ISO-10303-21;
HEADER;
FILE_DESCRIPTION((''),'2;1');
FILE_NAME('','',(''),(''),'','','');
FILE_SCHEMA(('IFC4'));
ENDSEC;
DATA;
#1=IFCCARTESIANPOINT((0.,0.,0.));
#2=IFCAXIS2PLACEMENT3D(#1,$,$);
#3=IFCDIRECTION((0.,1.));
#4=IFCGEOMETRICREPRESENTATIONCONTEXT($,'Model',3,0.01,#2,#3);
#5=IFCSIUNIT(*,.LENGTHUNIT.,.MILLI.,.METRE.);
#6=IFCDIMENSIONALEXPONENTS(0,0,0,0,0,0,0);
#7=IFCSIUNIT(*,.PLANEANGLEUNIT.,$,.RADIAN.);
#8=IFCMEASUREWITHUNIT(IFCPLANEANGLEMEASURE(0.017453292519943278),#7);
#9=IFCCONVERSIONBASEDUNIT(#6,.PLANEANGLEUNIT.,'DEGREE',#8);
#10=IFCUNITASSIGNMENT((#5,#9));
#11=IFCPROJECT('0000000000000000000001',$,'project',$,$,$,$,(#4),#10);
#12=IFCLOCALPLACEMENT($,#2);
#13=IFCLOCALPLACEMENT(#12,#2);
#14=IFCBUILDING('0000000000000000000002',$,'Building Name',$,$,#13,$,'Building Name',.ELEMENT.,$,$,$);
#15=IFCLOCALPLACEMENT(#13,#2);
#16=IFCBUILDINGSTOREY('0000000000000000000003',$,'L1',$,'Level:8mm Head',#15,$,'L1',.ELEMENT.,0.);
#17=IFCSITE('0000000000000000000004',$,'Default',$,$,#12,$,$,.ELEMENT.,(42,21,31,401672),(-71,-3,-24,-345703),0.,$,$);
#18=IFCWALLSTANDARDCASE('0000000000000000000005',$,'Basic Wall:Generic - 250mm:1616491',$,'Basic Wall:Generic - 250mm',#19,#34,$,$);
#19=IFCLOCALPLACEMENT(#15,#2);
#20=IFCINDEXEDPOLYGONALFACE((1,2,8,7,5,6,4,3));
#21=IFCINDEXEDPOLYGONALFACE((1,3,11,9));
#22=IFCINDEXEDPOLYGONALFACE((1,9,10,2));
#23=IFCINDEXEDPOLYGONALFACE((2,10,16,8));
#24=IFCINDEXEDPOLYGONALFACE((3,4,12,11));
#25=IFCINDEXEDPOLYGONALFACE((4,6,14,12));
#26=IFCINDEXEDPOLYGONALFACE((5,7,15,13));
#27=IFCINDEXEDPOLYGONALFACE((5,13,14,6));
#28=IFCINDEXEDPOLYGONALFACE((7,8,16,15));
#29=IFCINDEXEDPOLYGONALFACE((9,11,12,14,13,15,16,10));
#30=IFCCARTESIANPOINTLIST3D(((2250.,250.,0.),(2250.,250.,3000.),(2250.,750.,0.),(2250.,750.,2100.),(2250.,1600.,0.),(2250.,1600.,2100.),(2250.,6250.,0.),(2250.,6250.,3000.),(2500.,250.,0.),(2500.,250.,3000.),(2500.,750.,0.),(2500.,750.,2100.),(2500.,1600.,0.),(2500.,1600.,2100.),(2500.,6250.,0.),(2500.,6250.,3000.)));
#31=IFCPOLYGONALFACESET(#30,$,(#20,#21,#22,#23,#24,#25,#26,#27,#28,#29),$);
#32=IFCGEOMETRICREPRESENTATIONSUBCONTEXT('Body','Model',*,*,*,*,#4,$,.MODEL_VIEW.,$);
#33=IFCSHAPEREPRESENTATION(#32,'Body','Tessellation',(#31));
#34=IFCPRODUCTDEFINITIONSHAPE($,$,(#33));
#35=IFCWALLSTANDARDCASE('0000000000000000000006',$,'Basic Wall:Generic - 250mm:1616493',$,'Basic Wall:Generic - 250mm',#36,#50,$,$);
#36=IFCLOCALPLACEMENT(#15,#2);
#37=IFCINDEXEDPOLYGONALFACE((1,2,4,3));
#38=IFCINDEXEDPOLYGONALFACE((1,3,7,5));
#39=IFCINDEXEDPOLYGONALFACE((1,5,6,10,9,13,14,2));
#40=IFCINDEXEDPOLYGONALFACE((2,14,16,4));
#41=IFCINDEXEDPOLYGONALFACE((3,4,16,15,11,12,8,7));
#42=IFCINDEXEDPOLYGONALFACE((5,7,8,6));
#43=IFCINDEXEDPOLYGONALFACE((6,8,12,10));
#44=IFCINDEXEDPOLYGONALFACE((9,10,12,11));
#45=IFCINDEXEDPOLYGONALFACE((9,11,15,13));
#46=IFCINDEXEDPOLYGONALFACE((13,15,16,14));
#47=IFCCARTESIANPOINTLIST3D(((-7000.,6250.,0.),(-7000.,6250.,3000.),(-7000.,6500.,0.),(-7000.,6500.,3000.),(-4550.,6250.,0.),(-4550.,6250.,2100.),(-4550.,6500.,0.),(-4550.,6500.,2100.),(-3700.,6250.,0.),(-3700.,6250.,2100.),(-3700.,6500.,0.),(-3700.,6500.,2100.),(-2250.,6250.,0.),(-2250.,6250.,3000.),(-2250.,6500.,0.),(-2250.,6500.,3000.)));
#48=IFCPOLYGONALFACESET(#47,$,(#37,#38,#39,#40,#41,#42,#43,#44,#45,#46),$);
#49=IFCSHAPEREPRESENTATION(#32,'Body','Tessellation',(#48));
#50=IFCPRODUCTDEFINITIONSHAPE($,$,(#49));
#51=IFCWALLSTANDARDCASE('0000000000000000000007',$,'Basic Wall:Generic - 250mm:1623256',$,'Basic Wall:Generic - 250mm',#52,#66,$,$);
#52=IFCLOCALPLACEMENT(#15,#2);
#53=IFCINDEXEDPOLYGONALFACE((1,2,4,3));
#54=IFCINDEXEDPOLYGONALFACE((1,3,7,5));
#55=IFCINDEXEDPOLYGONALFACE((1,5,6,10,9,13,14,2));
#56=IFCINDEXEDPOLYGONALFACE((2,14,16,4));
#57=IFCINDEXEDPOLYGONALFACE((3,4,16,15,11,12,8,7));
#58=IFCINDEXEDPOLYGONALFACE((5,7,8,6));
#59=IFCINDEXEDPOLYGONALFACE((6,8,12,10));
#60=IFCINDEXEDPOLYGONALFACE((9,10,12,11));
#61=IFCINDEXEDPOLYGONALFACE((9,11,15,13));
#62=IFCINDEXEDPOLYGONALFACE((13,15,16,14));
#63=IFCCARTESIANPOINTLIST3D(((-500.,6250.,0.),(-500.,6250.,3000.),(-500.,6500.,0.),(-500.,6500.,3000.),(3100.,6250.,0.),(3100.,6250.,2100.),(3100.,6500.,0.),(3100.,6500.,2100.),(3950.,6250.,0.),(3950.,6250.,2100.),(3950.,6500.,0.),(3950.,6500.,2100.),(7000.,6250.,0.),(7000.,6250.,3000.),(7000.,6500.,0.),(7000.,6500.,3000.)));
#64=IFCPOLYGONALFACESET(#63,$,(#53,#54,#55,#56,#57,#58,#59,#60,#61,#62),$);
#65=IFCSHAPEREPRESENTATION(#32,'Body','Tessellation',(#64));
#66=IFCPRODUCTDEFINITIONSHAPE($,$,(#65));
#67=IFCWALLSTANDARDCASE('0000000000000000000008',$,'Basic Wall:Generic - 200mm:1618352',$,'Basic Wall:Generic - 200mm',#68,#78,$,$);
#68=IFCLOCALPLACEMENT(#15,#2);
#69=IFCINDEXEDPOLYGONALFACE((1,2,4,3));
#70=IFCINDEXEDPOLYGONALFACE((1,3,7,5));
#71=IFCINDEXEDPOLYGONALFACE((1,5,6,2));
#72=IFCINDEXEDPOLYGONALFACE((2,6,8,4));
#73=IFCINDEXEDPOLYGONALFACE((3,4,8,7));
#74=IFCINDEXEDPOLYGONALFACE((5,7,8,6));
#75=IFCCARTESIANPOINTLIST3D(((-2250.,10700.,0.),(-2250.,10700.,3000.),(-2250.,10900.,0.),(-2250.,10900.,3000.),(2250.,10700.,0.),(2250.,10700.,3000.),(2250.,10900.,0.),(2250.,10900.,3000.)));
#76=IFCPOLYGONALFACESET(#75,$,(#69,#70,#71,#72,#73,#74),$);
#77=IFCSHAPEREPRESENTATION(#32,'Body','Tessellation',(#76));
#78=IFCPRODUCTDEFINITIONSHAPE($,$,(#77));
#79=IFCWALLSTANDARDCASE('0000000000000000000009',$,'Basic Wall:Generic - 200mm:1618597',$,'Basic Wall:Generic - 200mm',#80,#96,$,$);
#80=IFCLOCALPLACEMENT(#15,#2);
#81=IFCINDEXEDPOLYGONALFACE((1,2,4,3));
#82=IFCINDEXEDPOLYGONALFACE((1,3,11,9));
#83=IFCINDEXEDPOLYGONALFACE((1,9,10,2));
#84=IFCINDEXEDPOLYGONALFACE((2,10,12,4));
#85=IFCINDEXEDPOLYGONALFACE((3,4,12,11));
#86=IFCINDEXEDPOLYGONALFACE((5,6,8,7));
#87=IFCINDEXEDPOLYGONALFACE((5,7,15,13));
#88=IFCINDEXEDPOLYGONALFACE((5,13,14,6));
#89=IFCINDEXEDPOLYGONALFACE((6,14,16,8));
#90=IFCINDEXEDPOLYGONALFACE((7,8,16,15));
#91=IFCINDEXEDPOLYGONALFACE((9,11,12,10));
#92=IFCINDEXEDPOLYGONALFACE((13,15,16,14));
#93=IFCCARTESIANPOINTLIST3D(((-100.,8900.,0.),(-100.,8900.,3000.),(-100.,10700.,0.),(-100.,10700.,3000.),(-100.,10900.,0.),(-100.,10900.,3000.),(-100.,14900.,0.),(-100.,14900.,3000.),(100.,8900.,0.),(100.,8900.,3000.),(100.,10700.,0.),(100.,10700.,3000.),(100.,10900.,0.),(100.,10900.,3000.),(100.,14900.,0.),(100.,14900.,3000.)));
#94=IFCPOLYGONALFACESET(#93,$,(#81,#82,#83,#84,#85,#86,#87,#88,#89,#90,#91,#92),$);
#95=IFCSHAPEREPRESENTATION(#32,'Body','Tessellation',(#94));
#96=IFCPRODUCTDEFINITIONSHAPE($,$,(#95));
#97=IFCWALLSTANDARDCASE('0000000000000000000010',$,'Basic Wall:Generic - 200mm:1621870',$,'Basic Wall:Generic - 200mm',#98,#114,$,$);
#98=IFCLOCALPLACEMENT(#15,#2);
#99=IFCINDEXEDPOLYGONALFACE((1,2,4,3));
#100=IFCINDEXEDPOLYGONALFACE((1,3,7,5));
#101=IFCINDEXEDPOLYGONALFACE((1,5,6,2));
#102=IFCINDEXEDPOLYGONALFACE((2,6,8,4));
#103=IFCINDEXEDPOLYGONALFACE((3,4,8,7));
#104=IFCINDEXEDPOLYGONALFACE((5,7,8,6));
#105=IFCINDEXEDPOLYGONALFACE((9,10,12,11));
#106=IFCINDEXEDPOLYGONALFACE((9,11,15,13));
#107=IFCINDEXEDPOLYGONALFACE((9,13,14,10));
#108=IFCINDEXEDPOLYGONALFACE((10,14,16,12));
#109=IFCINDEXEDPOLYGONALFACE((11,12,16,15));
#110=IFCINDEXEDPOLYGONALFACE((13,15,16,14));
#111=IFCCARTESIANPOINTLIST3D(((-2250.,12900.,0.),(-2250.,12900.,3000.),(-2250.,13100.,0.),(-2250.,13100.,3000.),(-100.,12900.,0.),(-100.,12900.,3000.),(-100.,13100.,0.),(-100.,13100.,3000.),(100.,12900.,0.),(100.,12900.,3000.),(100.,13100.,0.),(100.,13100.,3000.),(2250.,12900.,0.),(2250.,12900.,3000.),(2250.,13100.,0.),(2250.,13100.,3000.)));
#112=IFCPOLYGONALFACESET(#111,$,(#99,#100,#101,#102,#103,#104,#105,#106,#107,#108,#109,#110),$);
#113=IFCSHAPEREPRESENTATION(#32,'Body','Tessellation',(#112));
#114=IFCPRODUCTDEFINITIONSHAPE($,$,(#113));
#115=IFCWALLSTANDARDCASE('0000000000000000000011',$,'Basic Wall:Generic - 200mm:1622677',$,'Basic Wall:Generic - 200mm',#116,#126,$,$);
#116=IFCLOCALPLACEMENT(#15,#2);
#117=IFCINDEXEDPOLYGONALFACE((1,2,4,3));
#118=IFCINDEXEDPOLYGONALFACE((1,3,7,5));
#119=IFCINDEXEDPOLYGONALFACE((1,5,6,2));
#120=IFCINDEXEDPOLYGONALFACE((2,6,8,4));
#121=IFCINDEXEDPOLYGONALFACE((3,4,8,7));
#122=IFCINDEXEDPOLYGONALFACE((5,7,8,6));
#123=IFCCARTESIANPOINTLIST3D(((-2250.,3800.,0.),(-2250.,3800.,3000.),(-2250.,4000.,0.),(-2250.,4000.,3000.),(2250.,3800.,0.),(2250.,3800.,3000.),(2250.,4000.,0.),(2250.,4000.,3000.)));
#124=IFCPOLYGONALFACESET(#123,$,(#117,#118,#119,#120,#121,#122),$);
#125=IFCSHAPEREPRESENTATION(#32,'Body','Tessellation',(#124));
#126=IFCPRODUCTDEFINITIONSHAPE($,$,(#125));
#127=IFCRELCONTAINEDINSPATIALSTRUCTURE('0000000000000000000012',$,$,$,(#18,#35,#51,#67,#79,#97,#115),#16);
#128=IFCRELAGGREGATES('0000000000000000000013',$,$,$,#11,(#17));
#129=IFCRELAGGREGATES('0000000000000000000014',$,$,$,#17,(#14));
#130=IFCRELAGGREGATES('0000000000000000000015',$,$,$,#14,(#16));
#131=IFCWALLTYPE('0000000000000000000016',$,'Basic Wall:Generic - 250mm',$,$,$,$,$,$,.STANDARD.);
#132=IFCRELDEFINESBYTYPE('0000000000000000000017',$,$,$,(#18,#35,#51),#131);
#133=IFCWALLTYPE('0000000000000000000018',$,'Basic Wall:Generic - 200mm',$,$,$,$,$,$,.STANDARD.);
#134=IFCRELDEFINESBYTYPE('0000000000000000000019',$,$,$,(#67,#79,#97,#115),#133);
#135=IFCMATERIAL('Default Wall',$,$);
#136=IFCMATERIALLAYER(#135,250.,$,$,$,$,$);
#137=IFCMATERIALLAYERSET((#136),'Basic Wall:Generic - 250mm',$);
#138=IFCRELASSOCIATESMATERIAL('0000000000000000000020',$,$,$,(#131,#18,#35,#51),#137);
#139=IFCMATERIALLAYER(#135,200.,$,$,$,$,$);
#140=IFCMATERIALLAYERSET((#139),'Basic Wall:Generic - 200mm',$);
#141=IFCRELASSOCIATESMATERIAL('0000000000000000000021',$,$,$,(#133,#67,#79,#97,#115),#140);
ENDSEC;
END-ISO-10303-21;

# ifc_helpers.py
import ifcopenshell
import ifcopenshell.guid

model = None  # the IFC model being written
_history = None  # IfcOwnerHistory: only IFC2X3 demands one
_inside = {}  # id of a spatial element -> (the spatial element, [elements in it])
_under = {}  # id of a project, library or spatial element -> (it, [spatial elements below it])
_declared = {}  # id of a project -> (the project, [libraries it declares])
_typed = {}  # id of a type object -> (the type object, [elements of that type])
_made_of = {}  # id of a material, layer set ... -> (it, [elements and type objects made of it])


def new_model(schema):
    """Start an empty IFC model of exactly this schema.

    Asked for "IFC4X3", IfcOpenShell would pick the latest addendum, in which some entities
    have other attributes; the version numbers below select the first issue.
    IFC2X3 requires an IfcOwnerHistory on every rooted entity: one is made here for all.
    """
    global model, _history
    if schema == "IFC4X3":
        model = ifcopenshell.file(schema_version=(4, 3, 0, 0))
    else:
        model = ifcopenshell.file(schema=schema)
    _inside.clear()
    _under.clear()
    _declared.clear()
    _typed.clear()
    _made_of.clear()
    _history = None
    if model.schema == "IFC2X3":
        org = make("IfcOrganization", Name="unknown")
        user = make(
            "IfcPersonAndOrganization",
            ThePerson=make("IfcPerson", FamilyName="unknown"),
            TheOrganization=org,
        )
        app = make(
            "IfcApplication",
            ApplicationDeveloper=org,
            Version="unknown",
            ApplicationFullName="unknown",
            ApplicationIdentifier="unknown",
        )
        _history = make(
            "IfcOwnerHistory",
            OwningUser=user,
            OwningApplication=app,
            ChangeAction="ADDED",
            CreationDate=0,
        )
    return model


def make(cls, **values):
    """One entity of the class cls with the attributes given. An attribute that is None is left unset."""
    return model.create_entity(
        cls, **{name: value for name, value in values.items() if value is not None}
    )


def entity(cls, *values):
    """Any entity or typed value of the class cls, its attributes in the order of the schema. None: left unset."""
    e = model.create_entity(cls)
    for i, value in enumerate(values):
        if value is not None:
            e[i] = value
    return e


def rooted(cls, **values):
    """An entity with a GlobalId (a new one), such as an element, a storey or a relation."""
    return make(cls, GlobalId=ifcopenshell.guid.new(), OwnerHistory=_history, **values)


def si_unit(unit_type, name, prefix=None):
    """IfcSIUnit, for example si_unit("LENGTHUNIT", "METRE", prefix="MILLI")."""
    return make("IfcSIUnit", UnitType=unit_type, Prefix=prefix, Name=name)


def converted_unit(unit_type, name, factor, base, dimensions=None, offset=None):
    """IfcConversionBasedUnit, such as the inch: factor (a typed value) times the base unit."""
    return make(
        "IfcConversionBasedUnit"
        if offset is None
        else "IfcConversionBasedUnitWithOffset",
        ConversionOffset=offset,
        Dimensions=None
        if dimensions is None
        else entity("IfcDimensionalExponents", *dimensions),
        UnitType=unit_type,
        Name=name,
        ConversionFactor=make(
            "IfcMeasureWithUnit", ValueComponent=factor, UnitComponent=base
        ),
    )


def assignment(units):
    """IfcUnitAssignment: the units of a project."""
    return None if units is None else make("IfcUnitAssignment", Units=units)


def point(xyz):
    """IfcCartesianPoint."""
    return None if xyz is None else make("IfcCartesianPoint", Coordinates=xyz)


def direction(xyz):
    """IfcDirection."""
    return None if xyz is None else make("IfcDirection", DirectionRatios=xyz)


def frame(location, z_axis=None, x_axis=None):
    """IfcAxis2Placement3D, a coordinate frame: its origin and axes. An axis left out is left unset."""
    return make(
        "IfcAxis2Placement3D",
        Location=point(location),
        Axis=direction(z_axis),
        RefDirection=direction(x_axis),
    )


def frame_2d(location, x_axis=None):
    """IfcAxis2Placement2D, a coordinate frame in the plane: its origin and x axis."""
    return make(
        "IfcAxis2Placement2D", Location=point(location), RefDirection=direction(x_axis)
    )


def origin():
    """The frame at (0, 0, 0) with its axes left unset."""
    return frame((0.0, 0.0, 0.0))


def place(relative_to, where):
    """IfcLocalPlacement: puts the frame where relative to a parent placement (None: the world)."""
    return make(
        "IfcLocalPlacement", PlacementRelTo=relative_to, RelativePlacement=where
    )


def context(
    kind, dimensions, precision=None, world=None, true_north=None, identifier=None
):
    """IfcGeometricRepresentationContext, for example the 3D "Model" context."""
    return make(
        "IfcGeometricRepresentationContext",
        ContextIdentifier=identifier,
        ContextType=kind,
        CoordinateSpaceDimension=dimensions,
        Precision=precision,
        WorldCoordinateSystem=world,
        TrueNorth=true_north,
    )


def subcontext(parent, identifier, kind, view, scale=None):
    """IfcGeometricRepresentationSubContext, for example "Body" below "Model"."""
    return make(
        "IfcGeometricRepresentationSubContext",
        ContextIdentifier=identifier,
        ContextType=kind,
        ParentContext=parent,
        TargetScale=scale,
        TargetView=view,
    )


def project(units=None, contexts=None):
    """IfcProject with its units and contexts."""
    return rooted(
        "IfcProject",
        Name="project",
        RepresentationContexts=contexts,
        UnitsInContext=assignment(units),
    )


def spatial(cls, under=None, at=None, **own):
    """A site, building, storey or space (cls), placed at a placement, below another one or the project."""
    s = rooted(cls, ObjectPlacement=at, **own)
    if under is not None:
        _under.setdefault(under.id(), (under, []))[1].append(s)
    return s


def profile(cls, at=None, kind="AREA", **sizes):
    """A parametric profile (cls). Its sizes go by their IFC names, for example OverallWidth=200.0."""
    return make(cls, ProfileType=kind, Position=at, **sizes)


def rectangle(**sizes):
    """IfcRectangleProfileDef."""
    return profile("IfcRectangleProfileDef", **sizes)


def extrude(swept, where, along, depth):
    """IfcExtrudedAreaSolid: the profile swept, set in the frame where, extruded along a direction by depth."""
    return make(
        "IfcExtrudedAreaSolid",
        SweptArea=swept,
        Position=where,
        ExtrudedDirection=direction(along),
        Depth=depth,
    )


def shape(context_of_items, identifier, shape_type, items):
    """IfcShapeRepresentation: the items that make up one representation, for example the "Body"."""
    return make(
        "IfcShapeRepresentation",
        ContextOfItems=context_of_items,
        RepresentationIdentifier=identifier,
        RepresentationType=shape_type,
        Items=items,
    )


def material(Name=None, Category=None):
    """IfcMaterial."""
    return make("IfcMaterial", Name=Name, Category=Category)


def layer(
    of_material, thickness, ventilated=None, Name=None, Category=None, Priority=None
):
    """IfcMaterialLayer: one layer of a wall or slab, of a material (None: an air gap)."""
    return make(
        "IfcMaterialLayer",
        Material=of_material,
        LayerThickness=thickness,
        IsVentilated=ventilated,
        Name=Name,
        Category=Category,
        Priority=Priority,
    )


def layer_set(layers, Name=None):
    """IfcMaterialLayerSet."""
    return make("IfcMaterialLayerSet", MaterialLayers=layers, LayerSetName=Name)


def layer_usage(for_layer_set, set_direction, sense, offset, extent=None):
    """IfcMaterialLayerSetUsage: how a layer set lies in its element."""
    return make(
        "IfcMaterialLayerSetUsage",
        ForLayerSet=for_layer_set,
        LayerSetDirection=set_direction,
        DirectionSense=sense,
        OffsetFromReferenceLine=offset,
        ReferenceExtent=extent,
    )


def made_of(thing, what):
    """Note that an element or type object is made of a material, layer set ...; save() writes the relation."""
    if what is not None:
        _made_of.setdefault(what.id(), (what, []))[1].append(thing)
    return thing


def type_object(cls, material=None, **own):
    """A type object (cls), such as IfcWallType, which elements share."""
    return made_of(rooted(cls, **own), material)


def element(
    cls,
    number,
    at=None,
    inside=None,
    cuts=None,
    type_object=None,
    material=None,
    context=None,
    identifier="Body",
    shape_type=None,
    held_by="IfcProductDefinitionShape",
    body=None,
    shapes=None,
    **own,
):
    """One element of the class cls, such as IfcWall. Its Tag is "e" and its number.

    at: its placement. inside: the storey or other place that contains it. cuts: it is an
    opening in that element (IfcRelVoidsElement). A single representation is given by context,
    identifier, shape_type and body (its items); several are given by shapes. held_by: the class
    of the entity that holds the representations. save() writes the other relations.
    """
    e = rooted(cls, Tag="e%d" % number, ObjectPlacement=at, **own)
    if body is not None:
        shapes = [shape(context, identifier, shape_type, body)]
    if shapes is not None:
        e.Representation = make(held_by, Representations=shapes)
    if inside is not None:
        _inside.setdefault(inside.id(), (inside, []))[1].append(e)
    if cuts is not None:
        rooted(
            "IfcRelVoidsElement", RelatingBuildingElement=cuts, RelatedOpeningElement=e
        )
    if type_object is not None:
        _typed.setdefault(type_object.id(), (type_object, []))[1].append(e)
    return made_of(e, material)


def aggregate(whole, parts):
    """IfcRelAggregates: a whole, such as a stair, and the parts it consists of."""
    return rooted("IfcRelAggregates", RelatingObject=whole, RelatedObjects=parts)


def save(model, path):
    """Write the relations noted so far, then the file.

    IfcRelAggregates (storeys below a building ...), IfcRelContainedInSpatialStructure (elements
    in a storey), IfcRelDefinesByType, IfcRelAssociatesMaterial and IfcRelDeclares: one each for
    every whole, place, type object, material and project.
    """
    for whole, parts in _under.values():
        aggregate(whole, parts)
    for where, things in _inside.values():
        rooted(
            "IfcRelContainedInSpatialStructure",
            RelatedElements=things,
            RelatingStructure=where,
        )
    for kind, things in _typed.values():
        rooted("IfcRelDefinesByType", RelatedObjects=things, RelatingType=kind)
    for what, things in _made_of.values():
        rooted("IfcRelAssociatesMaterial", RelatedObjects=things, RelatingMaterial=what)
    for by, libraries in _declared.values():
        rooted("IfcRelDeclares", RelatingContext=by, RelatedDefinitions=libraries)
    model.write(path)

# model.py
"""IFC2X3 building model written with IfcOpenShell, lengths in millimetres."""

from ifc_helpers import new_model, entity, si_unit, converted_unit, direction, frame, frame_2d, origin, place, context, subcontext, project, spatial, rectangle, extrude, material, layer, layer_set, layer_usage, type_object, element, save


model = new_model("IFC2X3")

# Units and contexts
model_context = context("Model", 3, precision=0.01, world=origin(), true_north=direction((0.0, 1.0)))
body_context = subcontext(model_context, "Body", "Model", "MODEL_VIEW")
ifc_project = project(units=[si_unit("LENGTHUNIT", "METRE", prefix="MILLI"), converted_unit("PLANEANGLEUNIT", "DEGREE", entity("IfcPlaneAngleMeasure", 0.017453292519943278), si_unit("PLANEANGLEUNIT", "RADIAN"), dimensions=[0, 0, 0, 0, 0, 0, 0])], contexts=[model_context])

# Site, building, storey
site_placement = place(None, origin())
site = spatial("IfcSite", under=ifc_project, at=site_placement, Name="Default", CompositionType="ELEMENT", RefLatitude=(42, 21, 31, 401672), RefLongitude=(-71, -3, -24, -345703), RefElevation=0.0)
building_placement = place(site_placement, origin())
building = spatial("IfcBuilding", under=site, at=building_placement, Name="Building Name", LongName="Building Name", CompositionType="ELEMENT")
storey_placement = place(building_placement, origin())
storey = spatial("IfcBuildingStorey", under=building, at=storey_placement, Name="L1", ObjectType="Level:8mm Head", LongName="L1", CompositionType="ELEMENT", Elevation=0.0)

# Shared definitions
ifc_material = material(Name="Default Wall")
ifc_layer_1 = layer(ifc_material, 250.0)
ifc_layer_set_1 = layer_set([ifc_layer_1], Name="Basic Wall:Generic - 250mm")
wall_type_1 = type_object("IfcWallType", Name="Basic Wall:Generic - 250mm", PredefinedType="STANDARD", material=ifc_layer_set_1)

# Walls, openings
ifc_layer_usage_1 = layer_usage(ifc_layer_set_1, "AXIS2", "NEGATIVE", 125.0)
wall_1_placement = place(storey_placement, frame((2375.0, 250.0, 0.0), z_axis=(0.0, 0.0, 1.0), x_axis=(0.0, 1.0, 0.0)))
wall_1 = element("IfcWallStandardCase", 1, at=wall_1_placement, inside=storey, type_object=wall_type_1, material=ifc_layer_usage_1, Name="Basic Wall:Generic - 250mm:1616491", ObjectType="Basic Wall:Generic - 250mm", context=body_context, shape_type="SweptSolid", body=[
    extrude(rectangle(XDim=6000.0, YDim=250.0, at=frame_2d((3000.0, 0.0), x_axis=(1.0, 0.0))), origin(), (0.0, 0.0, 1.0), 3000.0),
])
opening_1_placement = place(wall_1_placement, frame((500.0, -125.0, 0.0)))
element("IfcOpeningElement", 2, at=opening_1_placement, cuts=wall_1, ObjectType="Opening", context=body_context, shape_type="SweptSolid", body=[
    extrude(rectangle(XDim=2100.0, YDim=850.0, at=frame_2d((1050.0, 425.0), x_axis=(1.0, 0.0))), frame((0.0, 0.0, 0.0), z_axis=(0.0, 1.0, 0.0), x_axis=(0.0, 0.0, 1.0)), (0.0, 0.0, 1.0), 250.0),
])
ifc_layer_usage_2 = layer_usage(ifc_layer_set_1, "AXIS2", "NEGATIVE", 125.0)
wall_2_placement = place(storey_placement, frame((-7000.0, 6375.0, 0.0)))
wall_2 = element("IfcWallStandardCase", 3, at=wall_2_placement, inside=storey, type_object=wall_type_1, material=ifc_layer_usage_2, Name="Basic Wall:Generic - 250mm:1616493", ObjectType="Basic Wall:Generic - 250mm", context=body_context, shape_type="SweptSolid", body=[
    extrude(rectangle(XDim=4750.0, YDim=250.0, at=frame_2d((2375.0, 0.0), x_axis=(1.0, 0.0))), origin(), (0.0, 0.0, 1.0), 3000.0),
])
opening_2_placement = place(wall_2_placement, frame((3300.0, 125.0, 0.0)))
element("IfcOpeningElement", 4, at=opening_2_placement, cuts=wall_2, ObjectType="Opening", context=body_context, shape_type="SweptSolid", body=[
    extrude(rectangle(XDim=2100.0, YDim=850.0, at=frame_2d((1050.0, 425.0), x_axis=(1.0, 0.0))), frame((0.0, 0.0, 0.0), z_axis=(0.0, -1.0, 0.0), x_axis=(0.0, 0.0, 1.0)), (0.0, 0.0, 1.0), 250.0),
])

# Wall, openings
ifc_layer_usage_3 = layer_usage(ifc_layer_set_1, "AXIS2", "NEGATIVE", 125.0)
wall_3_placement = place(storey_placement, frame((-500.0, 6375.0, 0.0)))
wall_3 = element("IfcWallStandardCase", 5, at=wall_3_placement, inside=storey, type_object=wall_type_1, material=ifc_layer_usage_3, Name="Basic Wall:Generic - 250mm:1623256", ObjectType="Basic Wall:Generic - 250mm", context=body_context, shape_type="SweptSolid", body=[
    extrude(rectangle(XDim=7500.0, YDim=250.0, at=frame_2d((3750.0, 0.0), x_axis=(1.0, 0.0))), origin(), (0.0, 0.0, 1.0), 3000.0),
])
opening_3_placement = place(wall_3_placement, frame((4450.0, 125.0, 0.0)))
element("IfcOpeningElement", 6, at=opening_3_placement, cuts=wall_3, ObjectType="Opening", context=body_context, shape_type="SweptSolid", body=[
    extrude(rectangle(XDim=2100.0, YDim=850.0, at=frame_2d((1050.0, 425.0), x_axis=(1.0, 0.0))), frame((0.0, 0.0, 0.0), z_axis=(0.0, -1.0, 0.0), x_axis=(0.0, 0.0, 1.0)), (0.0, 0.0, 1.0), 250.0),
])
opening_4_placement = place(wall_3_placement, frame((500.0, -6375.0, 0.0)))
element("IfcOpeningElement", 7, at=opening_4_placement, cuts=wall_3, ObjectType="Opening", context=body_context, shape_type="SweptSolid", body=[
    extrude(rectangle(XDim=2100.0, YDim=850.0, at=frame_2d((0.0, 0.0), x_axis=(1.0, 0.0))), frame((3525.0, 4976.0, 1050.0), z_axis=(0.0, 1.0, 0.0), x_axis=(0.0, 0.0, 1.0)), (0.0, 0.0, 1.0), 3048.0),
])

# Wall
ifc_layer_2 = layer(ifc_material, 200.0)
ifc_layer_set_2 = layer_set([ifc_layer_2], Name="Basic Wall:Generic - 200mm")
ifc_layer_usage_4 = layer_usage(ifc_layer_set_2, "AXIS2", "NEGATIVE", 100.0)
wall_type_2 = type_object("IfcWallType", Name="Basic Wall:Generic - 200mm", PredefinedType="STANDARD", material=ifc_layer_set_2)
wall_4_placement = place(storey_placement, frame((-2250.0, 10800.0, 0.0)))
element("IfcWallStandardCase", 8, at=wall_4_placement, inside=storey, type_object=wall_type_2, material=ifc_layer_usage_4, Name="Basic Wall:Generic - 200mm:1618352", ObjectType="Basic Wall:Generic - 200mm", context=body_context, shape_type="SweptSolid", body=[
    extrude(rectangle(XDim=4500.0, YDim=200.0, at=frame_2d((2250.0, 0.0), x_axis=(-1.0, 0.0))), origin(), (0.0, 0.0, 1.0), 3000.0),
])

# Walls, openings
ifc_layer_usage_5 = layer_usage(ifc_layer_set_2, "AXIS2", "NEGATIVE", 100.0)
wall_5_placement = place(storey_placement, frame((0.0, 8900.0, 0.0), z_axis=(0.0, 0.0, 1.0), x_axis=(0.0, 1.0, 0.0)))
wall_5 = element("IfcWallStandardCase", 9, at=wall_5_placement, inside=storey, type_object=wall_type_2, material=ifc_layer_usage_5, Name="Basic Wall:Generic - 200mm:1618597", ObjectType="Basic Wall:Generic - 200mm", context=body_context, shape_type="SweptSolid", body=[
    extrude(rectangle(XDim=6000.0, YDim=200.0, at=frame_2d((3000.0, 0.0), x_axis=(-1.0, 0.0))), origin(), (0.0, 0.0, 1.0), 3000.0),
])
opening_5_placement = place(storey_placement, frame((0.0, 8900.0, 0.0), z_axis=(0.0, 0.0, 1.0), x_axis=(0.0, 1.0, 0.0)))
element("IfcOpeningElement", 10, at=opening_5_placement, cuts=wall_5, ObjectType="Opening", context=body_context, shape_type="SweptSolid", body=[
    extrude(rectangle(XDim=3000.0, YDim=200.0, at=frame_2d((0.0, 0.0), x_axis=(1.0, 0.0))), frame((1800.0, 0.0, 1500.0), z_axis=(1.0, 0.0, 0.0), x_axis=(0.0, 0.0, -1.0)), (0.0, 0.0, 1.0), 200.0),
])
ifc_layer_usage_6 = layer_usage(ifc_layer_set_2, "AXIS2", "NEGATIVE", 100.0)
wall_6_placement = place(storey_placement, frame((-2250.0, 13000.0, 0.0)))
wall_6 = element("IfcWallStandardCase", 11, at=wall_6_placement, inside=storey, type_object=wall_type_2, material=ifc_layer_usage_6, Name="Basic Wall:Generic - 200mm:1621870", ObjectType="Basic Wall:Generic - 200mm", context=body_context, shape_type="SweptSolid", body=[
    extrude(rectangle(XDim=4500.0, YDim=200.0, at=frame_2d((2250.0, 0.0), x_axis=(-1.0, 0.0))), origin(), (0.0, 0.0, 1.0), 3000.0),
])
opening_6_placement = place(storey_placement, frame((-2250.0, 13000.0, 0.0)))
element("IfcOpeningElement", 12, at=opening_6_placement, cuts=wall_6, ObjectType="Opening", context=body_context, shape_type="SweptSolid", body=[
    extrude(rectangle(XDim=3000.0, YDim=200.0, at=frame_2d((0.0, 0.0), x_axis=(1.0, 0.0))), frame((2150.0, 0.0, 1500.0), z_axis=(1.0, 0.0, 0.0), x_axis=(0.0, 0.0, -1.0)), (0.0, 0.0, 1.0), 200.0),
])

# Wall
ifc_layer_usage_7 = layer_usage(ifc_layer_set_2, "AXIS2", "NEGATIVE", 100.0)
wall_7_placement = place(storey_placement, frame((-2250.0, 3900.0, 0.0)))
element("IfcWallStandardCase", 13, at=wall_7_placement, inside=storey, type_object=wall_type_2, material=ifc_layer_usage_7, Name="Basic Wall:Generic - 200mm:1622677", ObjectType="Basic Wall:Generic - 200mm", context=body_context, shape_type="SweptSolid", body=[
    extrude(rectangle(XDim=4500.0, YDim=200.0, at=frame_2d((2250.0, 0.0), x_axis=(-1.0, 0.0))), origin(), (0.0, 0.0, 1.0), 3000.0),
])

save(model, "model.ifc")
